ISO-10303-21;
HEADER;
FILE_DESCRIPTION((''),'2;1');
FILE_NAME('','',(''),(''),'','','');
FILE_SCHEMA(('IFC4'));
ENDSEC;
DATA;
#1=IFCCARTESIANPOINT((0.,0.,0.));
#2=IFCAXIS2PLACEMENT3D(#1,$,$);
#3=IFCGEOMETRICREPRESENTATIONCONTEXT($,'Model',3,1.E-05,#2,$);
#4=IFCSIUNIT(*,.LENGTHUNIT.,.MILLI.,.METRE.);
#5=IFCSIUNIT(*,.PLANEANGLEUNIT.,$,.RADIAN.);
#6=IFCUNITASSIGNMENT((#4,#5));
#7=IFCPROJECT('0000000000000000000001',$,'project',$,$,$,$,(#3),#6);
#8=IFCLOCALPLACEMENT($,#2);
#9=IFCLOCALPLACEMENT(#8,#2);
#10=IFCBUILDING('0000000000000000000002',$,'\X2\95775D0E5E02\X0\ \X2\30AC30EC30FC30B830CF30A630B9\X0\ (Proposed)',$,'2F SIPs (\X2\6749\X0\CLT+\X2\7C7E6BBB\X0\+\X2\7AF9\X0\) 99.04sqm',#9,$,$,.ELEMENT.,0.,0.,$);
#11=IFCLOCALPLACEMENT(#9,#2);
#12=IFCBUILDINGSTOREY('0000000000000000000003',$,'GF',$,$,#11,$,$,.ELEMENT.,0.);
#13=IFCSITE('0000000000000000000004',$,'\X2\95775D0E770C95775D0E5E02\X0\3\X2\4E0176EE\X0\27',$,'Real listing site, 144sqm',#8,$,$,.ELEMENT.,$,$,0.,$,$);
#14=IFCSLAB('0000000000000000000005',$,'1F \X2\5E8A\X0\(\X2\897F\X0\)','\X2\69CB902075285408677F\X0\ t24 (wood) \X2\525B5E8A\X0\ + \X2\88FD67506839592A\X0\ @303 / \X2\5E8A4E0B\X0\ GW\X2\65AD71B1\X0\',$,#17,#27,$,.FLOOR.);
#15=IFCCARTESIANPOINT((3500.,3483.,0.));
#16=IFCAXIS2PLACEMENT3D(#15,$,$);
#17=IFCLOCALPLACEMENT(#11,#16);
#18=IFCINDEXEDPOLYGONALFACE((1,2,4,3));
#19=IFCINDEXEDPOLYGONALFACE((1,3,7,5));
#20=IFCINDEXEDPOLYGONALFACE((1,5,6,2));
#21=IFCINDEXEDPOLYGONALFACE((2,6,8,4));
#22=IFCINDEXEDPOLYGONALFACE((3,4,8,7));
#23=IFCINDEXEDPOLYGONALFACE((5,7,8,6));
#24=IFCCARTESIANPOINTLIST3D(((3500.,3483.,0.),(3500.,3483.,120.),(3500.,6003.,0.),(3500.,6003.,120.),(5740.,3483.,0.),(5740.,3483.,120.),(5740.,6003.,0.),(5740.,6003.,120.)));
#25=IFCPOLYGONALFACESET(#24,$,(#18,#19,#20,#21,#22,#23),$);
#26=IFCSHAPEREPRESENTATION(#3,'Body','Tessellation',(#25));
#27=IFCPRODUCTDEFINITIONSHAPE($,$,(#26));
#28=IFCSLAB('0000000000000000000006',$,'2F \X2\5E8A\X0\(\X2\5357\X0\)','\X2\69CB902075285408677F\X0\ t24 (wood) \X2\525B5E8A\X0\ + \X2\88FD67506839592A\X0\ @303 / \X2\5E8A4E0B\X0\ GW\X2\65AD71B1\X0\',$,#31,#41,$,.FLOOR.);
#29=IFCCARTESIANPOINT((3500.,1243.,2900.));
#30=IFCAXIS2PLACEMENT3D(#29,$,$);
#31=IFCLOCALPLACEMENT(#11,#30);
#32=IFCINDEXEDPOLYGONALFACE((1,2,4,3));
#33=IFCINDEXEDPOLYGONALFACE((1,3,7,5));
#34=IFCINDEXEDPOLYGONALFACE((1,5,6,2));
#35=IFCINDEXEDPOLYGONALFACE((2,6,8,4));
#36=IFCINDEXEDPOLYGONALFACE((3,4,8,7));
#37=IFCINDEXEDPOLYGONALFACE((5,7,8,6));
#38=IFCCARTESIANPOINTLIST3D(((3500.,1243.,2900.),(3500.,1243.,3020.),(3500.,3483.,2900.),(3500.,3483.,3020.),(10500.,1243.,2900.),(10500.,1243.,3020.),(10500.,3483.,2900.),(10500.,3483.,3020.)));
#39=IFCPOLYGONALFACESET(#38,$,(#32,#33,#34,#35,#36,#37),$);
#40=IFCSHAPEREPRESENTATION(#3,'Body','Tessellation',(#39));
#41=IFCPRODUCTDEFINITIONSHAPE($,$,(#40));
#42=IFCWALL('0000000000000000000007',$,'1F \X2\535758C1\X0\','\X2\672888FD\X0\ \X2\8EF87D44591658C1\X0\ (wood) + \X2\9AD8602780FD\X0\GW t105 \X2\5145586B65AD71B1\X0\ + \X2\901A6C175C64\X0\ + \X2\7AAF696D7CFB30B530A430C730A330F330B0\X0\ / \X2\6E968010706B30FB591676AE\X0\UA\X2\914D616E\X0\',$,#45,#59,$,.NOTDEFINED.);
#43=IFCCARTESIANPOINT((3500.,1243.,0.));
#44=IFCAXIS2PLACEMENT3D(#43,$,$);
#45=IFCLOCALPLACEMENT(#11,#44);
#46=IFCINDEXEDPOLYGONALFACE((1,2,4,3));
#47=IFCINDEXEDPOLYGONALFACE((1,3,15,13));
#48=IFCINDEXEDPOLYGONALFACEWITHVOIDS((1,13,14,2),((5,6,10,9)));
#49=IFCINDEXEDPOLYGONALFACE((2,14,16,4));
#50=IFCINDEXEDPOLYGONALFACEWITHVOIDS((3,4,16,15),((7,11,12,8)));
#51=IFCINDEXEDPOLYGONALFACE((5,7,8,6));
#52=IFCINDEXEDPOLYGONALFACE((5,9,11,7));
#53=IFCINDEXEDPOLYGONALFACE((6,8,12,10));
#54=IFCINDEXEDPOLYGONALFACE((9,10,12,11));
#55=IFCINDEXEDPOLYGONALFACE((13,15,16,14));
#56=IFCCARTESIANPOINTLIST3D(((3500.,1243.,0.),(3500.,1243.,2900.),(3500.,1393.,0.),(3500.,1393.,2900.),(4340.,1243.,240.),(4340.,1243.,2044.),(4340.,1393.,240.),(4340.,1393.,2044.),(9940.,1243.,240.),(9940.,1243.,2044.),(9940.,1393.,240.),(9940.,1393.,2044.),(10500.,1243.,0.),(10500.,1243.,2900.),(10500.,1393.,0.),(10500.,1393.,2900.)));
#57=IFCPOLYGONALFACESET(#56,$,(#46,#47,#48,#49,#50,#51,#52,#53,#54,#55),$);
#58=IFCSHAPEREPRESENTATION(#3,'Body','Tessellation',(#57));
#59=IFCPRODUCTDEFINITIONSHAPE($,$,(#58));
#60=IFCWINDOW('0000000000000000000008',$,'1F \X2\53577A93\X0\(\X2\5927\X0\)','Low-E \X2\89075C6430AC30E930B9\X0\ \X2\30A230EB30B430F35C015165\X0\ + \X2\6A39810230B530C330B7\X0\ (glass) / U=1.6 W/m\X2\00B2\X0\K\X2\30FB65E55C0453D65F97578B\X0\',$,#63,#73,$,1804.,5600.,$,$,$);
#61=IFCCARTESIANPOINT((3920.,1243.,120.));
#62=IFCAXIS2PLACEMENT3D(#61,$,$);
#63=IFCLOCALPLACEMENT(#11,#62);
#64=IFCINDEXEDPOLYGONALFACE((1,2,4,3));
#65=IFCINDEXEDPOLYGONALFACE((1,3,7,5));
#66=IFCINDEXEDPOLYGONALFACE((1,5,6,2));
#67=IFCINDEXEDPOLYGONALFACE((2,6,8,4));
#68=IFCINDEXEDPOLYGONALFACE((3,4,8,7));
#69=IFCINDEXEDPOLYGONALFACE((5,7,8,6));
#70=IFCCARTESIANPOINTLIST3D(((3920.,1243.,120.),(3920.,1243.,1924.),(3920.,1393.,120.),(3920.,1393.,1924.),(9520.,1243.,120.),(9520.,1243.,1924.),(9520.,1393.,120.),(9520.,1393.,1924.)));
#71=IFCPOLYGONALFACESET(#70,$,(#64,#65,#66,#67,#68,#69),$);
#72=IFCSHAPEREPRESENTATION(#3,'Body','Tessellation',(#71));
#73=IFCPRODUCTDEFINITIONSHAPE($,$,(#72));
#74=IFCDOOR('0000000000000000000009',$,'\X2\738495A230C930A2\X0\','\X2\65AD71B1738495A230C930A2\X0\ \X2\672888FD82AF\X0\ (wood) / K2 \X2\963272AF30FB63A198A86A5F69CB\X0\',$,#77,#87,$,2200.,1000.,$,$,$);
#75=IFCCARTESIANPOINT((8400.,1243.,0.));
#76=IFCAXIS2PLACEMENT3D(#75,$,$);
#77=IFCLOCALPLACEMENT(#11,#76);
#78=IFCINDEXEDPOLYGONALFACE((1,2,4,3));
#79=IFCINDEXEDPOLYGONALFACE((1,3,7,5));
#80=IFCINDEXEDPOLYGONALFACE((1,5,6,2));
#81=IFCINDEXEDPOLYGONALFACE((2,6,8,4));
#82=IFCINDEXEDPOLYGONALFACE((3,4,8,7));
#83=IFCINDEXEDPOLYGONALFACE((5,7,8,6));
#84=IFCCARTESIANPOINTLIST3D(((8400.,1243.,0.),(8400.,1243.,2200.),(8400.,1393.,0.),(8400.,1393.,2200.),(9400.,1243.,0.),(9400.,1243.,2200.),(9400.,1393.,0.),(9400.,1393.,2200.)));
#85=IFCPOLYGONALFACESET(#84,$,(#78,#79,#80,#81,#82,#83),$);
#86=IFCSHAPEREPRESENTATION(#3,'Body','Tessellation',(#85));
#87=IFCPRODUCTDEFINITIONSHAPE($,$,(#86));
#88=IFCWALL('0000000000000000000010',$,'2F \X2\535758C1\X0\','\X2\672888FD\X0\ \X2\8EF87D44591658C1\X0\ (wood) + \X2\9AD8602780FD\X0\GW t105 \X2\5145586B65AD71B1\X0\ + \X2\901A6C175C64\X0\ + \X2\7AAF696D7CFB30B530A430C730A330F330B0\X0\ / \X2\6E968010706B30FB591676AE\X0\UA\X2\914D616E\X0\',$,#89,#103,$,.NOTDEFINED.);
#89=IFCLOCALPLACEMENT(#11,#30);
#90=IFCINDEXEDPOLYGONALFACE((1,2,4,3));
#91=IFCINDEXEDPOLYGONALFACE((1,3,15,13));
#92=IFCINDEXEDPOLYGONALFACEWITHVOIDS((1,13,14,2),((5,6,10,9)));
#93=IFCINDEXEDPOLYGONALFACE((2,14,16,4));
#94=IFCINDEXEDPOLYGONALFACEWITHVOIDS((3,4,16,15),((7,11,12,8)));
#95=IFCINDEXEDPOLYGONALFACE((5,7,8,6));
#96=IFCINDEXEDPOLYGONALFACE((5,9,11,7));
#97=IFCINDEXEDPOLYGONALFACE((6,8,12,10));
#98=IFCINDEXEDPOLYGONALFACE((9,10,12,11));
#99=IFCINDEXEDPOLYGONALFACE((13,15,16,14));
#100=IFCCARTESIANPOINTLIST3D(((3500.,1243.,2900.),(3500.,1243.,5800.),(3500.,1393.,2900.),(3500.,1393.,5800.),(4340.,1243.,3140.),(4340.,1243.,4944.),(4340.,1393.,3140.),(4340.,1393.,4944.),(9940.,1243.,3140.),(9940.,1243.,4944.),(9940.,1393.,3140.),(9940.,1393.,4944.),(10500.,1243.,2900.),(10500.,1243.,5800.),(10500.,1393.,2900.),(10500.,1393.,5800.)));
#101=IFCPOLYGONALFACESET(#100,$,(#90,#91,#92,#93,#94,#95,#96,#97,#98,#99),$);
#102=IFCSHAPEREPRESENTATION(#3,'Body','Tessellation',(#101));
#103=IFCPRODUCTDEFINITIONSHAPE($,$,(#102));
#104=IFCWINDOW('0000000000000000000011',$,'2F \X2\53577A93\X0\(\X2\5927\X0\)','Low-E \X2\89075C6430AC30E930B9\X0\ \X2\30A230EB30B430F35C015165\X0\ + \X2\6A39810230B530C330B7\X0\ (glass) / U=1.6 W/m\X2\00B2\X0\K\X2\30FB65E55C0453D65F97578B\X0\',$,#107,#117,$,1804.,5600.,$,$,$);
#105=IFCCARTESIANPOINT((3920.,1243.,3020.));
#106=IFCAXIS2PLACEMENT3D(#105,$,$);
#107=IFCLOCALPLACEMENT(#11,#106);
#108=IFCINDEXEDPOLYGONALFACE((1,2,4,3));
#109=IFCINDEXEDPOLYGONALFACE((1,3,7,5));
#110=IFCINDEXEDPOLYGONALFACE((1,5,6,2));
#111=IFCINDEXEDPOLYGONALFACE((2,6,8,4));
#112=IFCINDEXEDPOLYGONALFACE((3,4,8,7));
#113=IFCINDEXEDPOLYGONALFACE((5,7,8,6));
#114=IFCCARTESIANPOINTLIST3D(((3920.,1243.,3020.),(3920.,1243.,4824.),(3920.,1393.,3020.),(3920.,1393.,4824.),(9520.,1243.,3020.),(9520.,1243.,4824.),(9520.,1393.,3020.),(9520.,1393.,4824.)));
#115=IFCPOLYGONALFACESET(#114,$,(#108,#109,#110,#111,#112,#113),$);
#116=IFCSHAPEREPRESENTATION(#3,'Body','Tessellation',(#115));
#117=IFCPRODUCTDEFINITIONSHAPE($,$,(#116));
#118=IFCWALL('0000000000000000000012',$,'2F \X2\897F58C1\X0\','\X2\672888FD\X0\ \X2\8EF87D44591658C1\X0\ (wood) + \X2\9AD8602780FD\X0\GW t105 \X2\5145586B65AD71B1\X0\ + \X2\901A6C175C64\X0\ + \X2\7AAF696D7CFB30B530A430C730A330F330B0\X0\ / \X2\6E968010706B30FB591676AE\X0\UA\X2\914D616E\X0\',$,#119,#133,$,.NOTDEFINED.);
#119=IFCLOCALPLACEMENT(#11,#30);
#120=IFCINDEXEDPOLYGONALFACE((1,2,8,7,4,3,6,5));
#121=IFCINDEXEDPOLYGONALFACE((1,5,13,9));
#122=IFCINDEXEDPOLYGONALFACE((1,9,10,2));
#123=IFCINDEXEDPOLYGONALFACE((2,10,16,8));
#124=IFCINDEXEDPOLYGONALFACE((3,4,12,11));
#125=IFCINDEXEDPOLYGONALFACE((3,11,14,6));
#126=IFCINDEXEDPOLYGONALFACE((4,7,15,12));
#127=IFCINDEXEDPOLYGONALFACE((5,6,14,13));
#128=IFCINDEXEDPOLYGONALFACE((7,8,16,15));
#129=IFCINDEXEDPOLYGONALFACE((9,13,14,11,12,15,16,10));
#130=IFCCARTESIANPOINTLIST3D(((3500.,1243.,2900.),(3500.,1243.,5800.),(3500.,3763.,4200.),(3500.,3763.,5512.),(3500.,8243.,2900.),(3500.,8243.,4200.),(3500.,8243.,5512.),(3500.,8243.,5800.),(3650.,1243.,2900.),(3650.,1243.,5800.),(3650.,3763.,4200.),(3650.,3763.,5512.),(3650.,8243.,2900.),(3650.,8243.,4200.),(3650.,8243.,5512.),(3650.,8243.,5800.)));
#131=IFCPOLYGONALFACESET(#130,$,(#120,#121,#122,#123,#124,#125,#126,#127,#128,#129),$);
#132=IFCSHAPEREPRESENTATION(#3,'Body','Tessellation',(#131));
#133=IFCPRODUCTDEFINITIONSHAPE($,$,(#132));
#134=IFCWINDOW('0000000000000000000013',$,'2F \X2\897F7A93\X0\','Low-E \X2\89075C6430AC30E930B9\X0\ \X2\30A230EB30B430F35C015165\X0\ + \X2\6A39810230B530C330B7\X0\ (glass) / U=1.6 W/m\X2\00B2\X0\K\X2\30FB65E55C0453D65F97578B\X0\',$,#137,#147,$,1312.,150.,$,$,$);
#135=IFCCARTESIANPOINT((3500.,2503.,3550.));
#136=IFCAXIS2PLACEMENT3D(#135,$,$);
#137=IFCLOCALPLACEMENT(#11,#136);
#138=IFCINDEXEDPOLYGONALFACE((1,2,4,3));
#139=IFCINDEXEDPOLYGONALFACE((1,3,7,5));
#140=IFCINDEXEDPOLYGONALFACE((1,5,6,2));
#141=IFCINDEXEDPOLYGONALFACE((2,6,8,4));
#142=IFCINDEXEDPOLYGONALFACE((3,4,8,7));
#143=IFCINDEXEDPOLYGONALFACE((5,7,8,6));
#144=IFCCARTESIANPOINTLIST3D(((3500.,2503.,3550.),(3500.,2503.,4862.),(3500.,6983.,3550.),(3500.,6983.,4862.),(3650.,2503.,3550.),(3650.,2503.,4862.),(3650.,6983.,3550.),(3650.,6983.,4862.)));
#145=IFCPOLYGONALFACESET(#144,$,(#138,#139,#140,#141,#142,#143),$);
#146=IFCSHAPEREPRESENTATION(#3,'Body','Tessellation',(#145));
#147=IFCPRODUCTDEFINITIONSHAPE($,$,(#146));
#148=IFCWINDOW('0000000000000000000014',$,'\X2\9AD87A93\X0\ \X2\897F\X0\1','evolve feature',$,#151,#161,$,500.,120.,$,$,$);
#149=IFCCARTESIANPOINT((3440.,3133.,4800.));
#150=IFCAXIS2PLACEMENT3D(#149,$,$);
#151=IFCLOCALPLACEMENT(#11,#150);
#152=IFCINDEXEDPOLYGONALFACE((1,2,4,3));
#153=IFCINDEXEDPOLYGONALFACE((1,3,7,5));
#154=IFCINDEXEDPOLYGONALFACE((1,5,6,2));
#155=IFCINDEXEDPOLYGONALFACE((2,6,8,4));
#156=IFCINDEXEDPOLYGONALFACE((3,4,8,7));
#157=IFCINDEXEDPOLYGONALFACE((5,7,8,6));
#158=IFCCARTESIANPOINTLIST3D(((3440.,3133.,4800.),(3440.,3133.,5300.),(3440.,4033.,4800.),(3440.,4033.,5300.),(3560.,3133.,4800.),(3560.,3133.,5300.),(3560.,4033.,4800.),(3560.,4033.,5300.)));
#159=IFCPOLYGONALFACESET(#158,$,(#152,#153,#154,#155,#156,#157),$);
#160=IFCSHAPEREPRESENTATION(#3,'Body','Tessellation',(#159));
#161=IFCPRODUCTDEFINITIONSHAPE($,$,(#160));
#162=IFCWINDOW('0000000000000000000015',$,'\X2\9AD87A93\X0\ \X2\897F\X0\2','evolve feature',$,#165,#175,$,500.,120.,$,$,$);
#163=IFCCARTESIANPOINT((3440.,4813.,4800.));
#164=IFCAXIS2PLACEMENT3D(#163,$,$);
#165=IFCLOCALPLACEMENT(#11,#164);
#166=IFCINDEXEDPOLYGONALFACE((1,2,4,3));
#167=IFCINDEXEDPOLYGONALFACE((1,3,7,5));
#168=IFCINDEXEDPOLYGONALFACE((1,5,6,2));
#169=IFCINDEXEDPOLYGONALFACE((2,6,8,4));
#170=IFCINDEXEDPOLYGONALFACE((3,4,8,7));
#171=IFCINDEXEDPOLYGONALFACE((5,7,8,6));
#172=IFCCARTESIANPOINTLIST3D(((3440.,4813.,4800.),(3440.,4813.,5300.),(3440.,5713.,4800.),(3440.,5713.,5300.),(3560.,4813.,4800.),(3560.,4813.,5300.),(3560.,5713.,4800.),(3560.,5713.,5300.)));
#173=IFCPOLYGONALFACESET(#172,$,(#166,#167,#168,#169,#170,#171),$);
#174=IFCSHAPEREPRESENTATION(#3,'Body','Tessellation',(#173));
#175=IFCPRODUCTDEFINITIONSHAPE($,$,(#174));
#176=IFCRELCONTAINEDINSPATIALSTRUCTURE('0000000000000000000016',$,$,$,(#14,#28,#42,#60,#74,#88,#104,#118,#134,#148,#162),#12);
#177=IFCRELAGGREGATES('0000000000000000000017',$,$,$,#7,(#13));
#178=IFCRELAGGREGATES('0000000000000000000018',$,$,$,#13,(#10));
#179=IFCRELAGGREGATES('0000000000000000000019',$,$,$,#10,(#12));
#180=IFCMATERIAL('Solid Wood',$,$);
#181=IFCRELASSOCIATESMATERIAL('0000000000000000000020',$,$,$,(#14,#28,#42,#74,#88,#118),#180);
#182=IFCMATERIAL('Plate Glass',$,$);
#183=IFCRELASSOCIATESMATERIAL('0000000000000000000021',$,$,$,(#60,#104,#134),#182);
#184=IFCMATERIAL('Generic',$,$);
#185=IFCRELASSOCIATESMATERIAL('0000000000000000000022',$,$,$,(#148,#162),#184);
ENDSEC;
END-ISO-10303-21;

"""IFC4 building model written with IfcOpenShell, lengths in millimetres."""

from ifc_helpers import new_model, si_unit, frame, frame_2d, origin, place, context, project, spatial, rectangle, extrude, material, element, fill, save


model = new_model("IFC4")

# Units and contexts
model_context = context("Model", 3, precision=1e-05, world=origin())
ifc_project = project(units=[si_unit("LENGTHUNIT", "METRE", prefix="MILLI"), si_unit("PLANEANGLEUNIT", "RADIAN")], contexts=[model_context])

# Site, building, storey
site_placement = place(None, origin())
site = spatial("IfcSite", under=ifc_project, at=site_placement, Name="長崎県長崎市3丁目27", ObjectType="Real listing site, 144sqm", CompositionType="ELEMENT", RefElevation=0.0)
building_placement = place(site_placement, origin())
building = spatial("IfcBuilding", under=site, at=building_placement, Name="長崎市 ガレージハウス (Proposed)", ObjectType="2F SIPs (杉CLT+籾殻+竹) 99.04sqm", CompositionType="ELEMENT", ElevationOfRefHeight=0.0, ElevationOfTerrain=0.0)
storey_placement = place(building_placement, origin())
storey = spatial("IfcBuildingStorey", under=building, at=storey_placement, Name="GF", CompositionType="ELEMENT", Elevation=0.0)

# Slabs
ifc_material_1 = material(Name="Solid Wood")
slab_1_placement = place(storey_placement, frame((3500.0, 3483.0, 0.0)))
element("IfcSlab", 1, at=slab_1_placement, inside=storey, material=ifc_material_1, Name="1F 床(西)", Description="構造用合板 t24 (wood) 剛床 + 製材根太 @303 / 床下 GW断熱", PredefinedType="FLOOR", context=model_context, shape_type="SweptSolid", body=[
    extrude(rectangle(XDim=2240.0, YDim=2520.0, at=frame_2d((1120.0, 1260.0))), frame((3500.0, 3483.0, 0.0)), (0.0, 0.0, 1.0), 120.0),
])
slab_2_placement = place(storey_placement, frame((3500.0, 1243.0, 2900.0)))
element("IfcSlab", 2, at=slab_2_placement, inside=storey, material=ifc_material_1, Name="2F 床(南)", Description="構造用合板 t24 (wood) 剛床 + 製材根太 @303 / 床下 GW断熱", PredefinedType="FLOOR", context=model_context, shape_type="SweptSolid", body=[
    extrude(rectangle(XDim=7000.0, YDim=2240.0, at=frame_2d((3500.0, 1120.0))), frame((3500.0, 1243.0, 2900.0)), (0.0, 0.0, 1.0), 120.0),
])
ifc_material_2 = material(Name="Generic")

# Wall, openings, window, door
wall_1_placement = place(storey_placement, frame((3500.0, 1243.0, 0.0)))
wall_1 = element("IfcWall", 3, at=wall_1_placement, inside=storey, material=ifc_material_1, Name="1F 南壁", Description="木製 軸組外壁 (wood) + 高性能GW t105 充填断熱 + 通気層 + 窯業系サイディング / 準耐火・外皮UA配慮", PredefinedType="NOTDEFINED", context=model_context, shape_type="SweptSolid", body=[
    extrude(rectangle(XDim=7000.0, YDim=150.0, at=frame_2d((3500.0, 75.0))), frame((3500.0, 1243.0, 0.0)), (0.0, 0.0, 1.0), 2900.0),
])
opening_1_placement = place(storey_placement, frame((3920.0, 1243.0, 120.0)))
opening_1 = element("IfcOpeningElement", 4, at=opening_1_placement, cuts=wall_1, PredefinedType="NOTDEFINED", context=model_context, shape_type="SweptSolid", body=[
    extrude(rectangle(XDim=5600.0, YDim=150.0, at=frame_2d((2800.0, 75.0))), frame((3920.0, 1243.0, 120.0)), (0.0, 0.0, 1.0), 1804.0),
])
opening_2_placement = place(storey_placement, frame((8400.0, 1243.0, 0.0)))
opening_2 = element("IfcOpeningElement", 5, at=opening_2_placement, cuts=wall_1, PredefinedType="NOTDEFINED", context=model_context, shape_type="SweptSolid", body=[
    extrude(rectangle(XDim=1000.0, YDim=150.0, at=frame_2d((500.0, 75.0))), frame((8400.0, 1243.0, 0.0)), (0.0, 0.0, 1.0), 2200.0),
])
ifc_material_3 = material(Name="Plate Glass")
window_1_placement = place(storey_placement, frame((3920.0, 1243.0, 120.0)))
window_1 = element("IfcWindow", 6, at=window_1_placement, inside=storey, material=ifc_material_3, Name="1F 南窓(大)", Description="Low-E 複層ガラス アルゴン封入 + 樹脂サッシ (glass) / U=1.6 W/m²K・日射取得型", OverallHeight=1804.0, OverallWidth=5600.0, context=model_context, shape_type="SweptSolid", body=[
    extrude(rectangle(XDim=5600.0, YDim=150.0, at=frame_2d((2800.0, 75.0))), frame((3920.0, 1243.0, 120.0)), (0.0, 0.0, 1.0), 1804.0),
])
fill(opening_1, window_1)
door_placement = place(storey_placement, frame((8400.0, 1243.0, 0.0)))
door = element("IfcDoor", 7, at=door_placement, inside=storey, material=ifc_material_1, Name="玄関ドア", Description="断熱玄関ドア 木製芯 (wood) / K2 防犯・採風機構", OverallHeight=2200.0, OverallWidth=1000.0, context=model_context, shape_type="SweptSolid", body=[
    extrude(rectangle(XDim=1000.0, YDim=150.0, at=frame_2d((500.0, 75.0))), frame((8400.0, 1243.0, 0.0)), (0.0, 0.0, 1.0), 2200.0),
])
fill(opening_2, door)

# Wall, opening, window
wall_2_placement = place(storey_placement, frame((3500.0, 1243.0, 2900.0)))
wall_2 = element("IfcWall", 8, at=wall_2_placement, inside=storey, material=ifc_material_1, Name="2F 南壁", Description="木製 軸組外壁 (wood) + 高性能GW t105 充填断熱 + 通気層 + 窯業系サイディング / 準耐火・外皮UA配慮", PredefinedType="NOTDEFINED", context=model_context, shape_type="SweptSolid", body=[
    extrude(rectangle(XDim=7000.0, YDim=150.0, at=frame_2d((3500.0, 75.0))), frame((3500.0, 1243.0, 2900.0)), (0.0, 0.0, 1.0), 2900.0),
])
opening_3_placement = place(storey_placement, frame((3920.0, 1243.0, 3020.0)))
opening_3 = element("IfcOpeningElement", 9, at=opening_3_placement, cuts=wall_2, PredefinedType="NOTDEFINED", context=model_context, shape_type="SweptSolid", body=[
    extrude(rectangle(XDim=5600.0, YDim=150.0, at=frame_2d((2800.0, 75.0))), frame((3920.0, 1243.0, 3020.0)), (0.0, 0.0, 1.0), 1804.0),
])
window_2_placement = place(storey_placement, frame((3920.0, 1243.0, 3020.0)))
window_2 = element("IfcWindow", 10, at=window_2_placement, inside=storey, material=ifc_material_3, Name="2F 南窓(大)", Description="Low-E 複層ガラス アルゴン封入 + 樹脂サッシ (glass) / U=1.6 W/m²K・日射取得型", OverallHeight=1804.0, OverallWidth=5600.0, context=model_context, shape_type="SweptSolid", body=[
    extrude(rectangle(XDim=5600.0, YDim=150.0, at=frame_2d((2800.0, 75.0))), frame((3920.0, 1243.0, 3020.0)), (0.0, 0.0, 1.0), 1804.0),
])
fill(opening_3, window_2)

# Wall, openings, windows
wall_3_placement = place(storey_placement, frame((3500.0, 1243.0, 2900.0)))
wall_3 = element("IfcWall", 11, at=wall_3_placement, inside=storey, material=ifc_material_1, Name="2F 西壁", Description="木製 軸組外壁 (wood) + 高性能GW t105 充填断熱 + 通気層 + 窯業系サイディング / 準耐火・外皮UA配慮", PredefinedType="NOTDEFINED", context=model_context, shape_type="SweptSolid", body=[
    extrude(rectangle(XDim=150.0, YDim=7000.0, at=frame_2d((75.0, 3500.0))), frame((3500.0, 1243.0, 2900.0)), (0.0, 0.0, 1.0), 2900.0),
])
opening_4_placement = place(storey_placement, frame((3500.0, 2503.0, 3550.0)))
opening_4 = element("IfcOpeningElement", 12, at=opening_4_placement, cuts=wall_3, PredefinedType="NOTDEFINED", context=model_context, shape_type="SweptSolid", body=[
    extrude(rectangle(XDim=150.0, YDim=4480.0, at=frame_2d((75.0, 2240.0))), frame((3500.0, 2503.0, 3550.0)), (0.0, 0.0, 1.0), 1312.0),
])
opening_5_placement = place(storey_placement, frame((3440.0, 3133.0, 4800.0)))
opening_5 = element("IfcOpeningElement", 13, at=opening_5_placement, cuts=wall_3, PredefinedType="NOTDEFINED", context=model_context, shape_type="SweptSolid", body=[
    extrude(rectangle(XDim=120.0, YDim=900.0, at=frame_2d((60.0, 450.0))), frame((3440.0, 3133.0, 4800.0)), (0.0, 0.0, 1.0), 500.0),
])
opening_6_placement = place(storey_placement, frame((3440.0, 4813.0, 4800.0)))
opening_6 = element("IfcOpeningElement", 14, at=opening_6_placement, cuts=wall_3, PredefinedType="NOTDEFINED", context=model_context, shape_type="SweptSolid", body=[
    extrude(rectangle(XDim=120.0, YDim=900.0, at=frame_2d((60.0, 450.0))), frame((3440.0, 4813.0, 4800.0)), (0.0, 0.0, 1.0), 500.0),
])
window_3_placement = place(storey_placement, frame((3500.0, 2503.0, 3550.0)))
window_3 = element("IfcWindow", 15, at=window_3_placement, inside=storey, material=ifc_material_3, Name="2F 西窓", Description="Low-E 複層ガラス アルゴン封入 + 樹脂サッシ (glass) / U=1.6 W/m²K・日射取得型", OverallHeight=1312.0, OverallWidth=150.0, context=model_context, shape_type="SweptSolid", body=[
    extrude(rectangle(XDim=150.0, YDim=4480.0, at=frame_2d((75.0, 2240.0))), frame((3500.0, 2503.0, 3550.0)), (0.0, 0.0, 1.0), 1312.0),
])
fill(opening_4, window_3)
window_4_placement = place(storey_placement, frame((3440.0, 3133.0, 4800.0)))
window_4 = element("IfcWindow", 16, at=window_4_placement, inside=storey, material=ifc_material_2, Name="高窓 西1", Description="evolve feature", OverallHeight=500.0, OverallWidth=120.0, context=model_context, shape_type="SweptSolid", body=[
    extrude(rectangle(XDim=120.0, YDim=900.0, at=frame_2d((60.0, 450.0))), frame((3440.0, 3133.0, 4800.0)), (0.0, 0.0, 1.0), 500.0),
])
fill(opening_5, window_4)
window_5_placement = place(storey_placement, frame((3440.0, 4813.0, 4800.0)))
window_5 = element("IfcWindow", 17, at=window_5_placement, inside=storey, material=ifc_material_2, Name="高窓 西2", Description="evolve feature", OverallHeight=500.0, OverallWidth=120.0, context=model_context, shape_type="SweptSolid", body=[
    extrude(rectangle(XDim=120.0, YDim=900.0, at=frame_2d((60.0, 450.0))), frame((3440.0, 4813.0, 4800.0)), (0.0, 0.0, 1.0), 500.0),
])
fill(opening_6, window_5)

save(model, "model.ifc")
